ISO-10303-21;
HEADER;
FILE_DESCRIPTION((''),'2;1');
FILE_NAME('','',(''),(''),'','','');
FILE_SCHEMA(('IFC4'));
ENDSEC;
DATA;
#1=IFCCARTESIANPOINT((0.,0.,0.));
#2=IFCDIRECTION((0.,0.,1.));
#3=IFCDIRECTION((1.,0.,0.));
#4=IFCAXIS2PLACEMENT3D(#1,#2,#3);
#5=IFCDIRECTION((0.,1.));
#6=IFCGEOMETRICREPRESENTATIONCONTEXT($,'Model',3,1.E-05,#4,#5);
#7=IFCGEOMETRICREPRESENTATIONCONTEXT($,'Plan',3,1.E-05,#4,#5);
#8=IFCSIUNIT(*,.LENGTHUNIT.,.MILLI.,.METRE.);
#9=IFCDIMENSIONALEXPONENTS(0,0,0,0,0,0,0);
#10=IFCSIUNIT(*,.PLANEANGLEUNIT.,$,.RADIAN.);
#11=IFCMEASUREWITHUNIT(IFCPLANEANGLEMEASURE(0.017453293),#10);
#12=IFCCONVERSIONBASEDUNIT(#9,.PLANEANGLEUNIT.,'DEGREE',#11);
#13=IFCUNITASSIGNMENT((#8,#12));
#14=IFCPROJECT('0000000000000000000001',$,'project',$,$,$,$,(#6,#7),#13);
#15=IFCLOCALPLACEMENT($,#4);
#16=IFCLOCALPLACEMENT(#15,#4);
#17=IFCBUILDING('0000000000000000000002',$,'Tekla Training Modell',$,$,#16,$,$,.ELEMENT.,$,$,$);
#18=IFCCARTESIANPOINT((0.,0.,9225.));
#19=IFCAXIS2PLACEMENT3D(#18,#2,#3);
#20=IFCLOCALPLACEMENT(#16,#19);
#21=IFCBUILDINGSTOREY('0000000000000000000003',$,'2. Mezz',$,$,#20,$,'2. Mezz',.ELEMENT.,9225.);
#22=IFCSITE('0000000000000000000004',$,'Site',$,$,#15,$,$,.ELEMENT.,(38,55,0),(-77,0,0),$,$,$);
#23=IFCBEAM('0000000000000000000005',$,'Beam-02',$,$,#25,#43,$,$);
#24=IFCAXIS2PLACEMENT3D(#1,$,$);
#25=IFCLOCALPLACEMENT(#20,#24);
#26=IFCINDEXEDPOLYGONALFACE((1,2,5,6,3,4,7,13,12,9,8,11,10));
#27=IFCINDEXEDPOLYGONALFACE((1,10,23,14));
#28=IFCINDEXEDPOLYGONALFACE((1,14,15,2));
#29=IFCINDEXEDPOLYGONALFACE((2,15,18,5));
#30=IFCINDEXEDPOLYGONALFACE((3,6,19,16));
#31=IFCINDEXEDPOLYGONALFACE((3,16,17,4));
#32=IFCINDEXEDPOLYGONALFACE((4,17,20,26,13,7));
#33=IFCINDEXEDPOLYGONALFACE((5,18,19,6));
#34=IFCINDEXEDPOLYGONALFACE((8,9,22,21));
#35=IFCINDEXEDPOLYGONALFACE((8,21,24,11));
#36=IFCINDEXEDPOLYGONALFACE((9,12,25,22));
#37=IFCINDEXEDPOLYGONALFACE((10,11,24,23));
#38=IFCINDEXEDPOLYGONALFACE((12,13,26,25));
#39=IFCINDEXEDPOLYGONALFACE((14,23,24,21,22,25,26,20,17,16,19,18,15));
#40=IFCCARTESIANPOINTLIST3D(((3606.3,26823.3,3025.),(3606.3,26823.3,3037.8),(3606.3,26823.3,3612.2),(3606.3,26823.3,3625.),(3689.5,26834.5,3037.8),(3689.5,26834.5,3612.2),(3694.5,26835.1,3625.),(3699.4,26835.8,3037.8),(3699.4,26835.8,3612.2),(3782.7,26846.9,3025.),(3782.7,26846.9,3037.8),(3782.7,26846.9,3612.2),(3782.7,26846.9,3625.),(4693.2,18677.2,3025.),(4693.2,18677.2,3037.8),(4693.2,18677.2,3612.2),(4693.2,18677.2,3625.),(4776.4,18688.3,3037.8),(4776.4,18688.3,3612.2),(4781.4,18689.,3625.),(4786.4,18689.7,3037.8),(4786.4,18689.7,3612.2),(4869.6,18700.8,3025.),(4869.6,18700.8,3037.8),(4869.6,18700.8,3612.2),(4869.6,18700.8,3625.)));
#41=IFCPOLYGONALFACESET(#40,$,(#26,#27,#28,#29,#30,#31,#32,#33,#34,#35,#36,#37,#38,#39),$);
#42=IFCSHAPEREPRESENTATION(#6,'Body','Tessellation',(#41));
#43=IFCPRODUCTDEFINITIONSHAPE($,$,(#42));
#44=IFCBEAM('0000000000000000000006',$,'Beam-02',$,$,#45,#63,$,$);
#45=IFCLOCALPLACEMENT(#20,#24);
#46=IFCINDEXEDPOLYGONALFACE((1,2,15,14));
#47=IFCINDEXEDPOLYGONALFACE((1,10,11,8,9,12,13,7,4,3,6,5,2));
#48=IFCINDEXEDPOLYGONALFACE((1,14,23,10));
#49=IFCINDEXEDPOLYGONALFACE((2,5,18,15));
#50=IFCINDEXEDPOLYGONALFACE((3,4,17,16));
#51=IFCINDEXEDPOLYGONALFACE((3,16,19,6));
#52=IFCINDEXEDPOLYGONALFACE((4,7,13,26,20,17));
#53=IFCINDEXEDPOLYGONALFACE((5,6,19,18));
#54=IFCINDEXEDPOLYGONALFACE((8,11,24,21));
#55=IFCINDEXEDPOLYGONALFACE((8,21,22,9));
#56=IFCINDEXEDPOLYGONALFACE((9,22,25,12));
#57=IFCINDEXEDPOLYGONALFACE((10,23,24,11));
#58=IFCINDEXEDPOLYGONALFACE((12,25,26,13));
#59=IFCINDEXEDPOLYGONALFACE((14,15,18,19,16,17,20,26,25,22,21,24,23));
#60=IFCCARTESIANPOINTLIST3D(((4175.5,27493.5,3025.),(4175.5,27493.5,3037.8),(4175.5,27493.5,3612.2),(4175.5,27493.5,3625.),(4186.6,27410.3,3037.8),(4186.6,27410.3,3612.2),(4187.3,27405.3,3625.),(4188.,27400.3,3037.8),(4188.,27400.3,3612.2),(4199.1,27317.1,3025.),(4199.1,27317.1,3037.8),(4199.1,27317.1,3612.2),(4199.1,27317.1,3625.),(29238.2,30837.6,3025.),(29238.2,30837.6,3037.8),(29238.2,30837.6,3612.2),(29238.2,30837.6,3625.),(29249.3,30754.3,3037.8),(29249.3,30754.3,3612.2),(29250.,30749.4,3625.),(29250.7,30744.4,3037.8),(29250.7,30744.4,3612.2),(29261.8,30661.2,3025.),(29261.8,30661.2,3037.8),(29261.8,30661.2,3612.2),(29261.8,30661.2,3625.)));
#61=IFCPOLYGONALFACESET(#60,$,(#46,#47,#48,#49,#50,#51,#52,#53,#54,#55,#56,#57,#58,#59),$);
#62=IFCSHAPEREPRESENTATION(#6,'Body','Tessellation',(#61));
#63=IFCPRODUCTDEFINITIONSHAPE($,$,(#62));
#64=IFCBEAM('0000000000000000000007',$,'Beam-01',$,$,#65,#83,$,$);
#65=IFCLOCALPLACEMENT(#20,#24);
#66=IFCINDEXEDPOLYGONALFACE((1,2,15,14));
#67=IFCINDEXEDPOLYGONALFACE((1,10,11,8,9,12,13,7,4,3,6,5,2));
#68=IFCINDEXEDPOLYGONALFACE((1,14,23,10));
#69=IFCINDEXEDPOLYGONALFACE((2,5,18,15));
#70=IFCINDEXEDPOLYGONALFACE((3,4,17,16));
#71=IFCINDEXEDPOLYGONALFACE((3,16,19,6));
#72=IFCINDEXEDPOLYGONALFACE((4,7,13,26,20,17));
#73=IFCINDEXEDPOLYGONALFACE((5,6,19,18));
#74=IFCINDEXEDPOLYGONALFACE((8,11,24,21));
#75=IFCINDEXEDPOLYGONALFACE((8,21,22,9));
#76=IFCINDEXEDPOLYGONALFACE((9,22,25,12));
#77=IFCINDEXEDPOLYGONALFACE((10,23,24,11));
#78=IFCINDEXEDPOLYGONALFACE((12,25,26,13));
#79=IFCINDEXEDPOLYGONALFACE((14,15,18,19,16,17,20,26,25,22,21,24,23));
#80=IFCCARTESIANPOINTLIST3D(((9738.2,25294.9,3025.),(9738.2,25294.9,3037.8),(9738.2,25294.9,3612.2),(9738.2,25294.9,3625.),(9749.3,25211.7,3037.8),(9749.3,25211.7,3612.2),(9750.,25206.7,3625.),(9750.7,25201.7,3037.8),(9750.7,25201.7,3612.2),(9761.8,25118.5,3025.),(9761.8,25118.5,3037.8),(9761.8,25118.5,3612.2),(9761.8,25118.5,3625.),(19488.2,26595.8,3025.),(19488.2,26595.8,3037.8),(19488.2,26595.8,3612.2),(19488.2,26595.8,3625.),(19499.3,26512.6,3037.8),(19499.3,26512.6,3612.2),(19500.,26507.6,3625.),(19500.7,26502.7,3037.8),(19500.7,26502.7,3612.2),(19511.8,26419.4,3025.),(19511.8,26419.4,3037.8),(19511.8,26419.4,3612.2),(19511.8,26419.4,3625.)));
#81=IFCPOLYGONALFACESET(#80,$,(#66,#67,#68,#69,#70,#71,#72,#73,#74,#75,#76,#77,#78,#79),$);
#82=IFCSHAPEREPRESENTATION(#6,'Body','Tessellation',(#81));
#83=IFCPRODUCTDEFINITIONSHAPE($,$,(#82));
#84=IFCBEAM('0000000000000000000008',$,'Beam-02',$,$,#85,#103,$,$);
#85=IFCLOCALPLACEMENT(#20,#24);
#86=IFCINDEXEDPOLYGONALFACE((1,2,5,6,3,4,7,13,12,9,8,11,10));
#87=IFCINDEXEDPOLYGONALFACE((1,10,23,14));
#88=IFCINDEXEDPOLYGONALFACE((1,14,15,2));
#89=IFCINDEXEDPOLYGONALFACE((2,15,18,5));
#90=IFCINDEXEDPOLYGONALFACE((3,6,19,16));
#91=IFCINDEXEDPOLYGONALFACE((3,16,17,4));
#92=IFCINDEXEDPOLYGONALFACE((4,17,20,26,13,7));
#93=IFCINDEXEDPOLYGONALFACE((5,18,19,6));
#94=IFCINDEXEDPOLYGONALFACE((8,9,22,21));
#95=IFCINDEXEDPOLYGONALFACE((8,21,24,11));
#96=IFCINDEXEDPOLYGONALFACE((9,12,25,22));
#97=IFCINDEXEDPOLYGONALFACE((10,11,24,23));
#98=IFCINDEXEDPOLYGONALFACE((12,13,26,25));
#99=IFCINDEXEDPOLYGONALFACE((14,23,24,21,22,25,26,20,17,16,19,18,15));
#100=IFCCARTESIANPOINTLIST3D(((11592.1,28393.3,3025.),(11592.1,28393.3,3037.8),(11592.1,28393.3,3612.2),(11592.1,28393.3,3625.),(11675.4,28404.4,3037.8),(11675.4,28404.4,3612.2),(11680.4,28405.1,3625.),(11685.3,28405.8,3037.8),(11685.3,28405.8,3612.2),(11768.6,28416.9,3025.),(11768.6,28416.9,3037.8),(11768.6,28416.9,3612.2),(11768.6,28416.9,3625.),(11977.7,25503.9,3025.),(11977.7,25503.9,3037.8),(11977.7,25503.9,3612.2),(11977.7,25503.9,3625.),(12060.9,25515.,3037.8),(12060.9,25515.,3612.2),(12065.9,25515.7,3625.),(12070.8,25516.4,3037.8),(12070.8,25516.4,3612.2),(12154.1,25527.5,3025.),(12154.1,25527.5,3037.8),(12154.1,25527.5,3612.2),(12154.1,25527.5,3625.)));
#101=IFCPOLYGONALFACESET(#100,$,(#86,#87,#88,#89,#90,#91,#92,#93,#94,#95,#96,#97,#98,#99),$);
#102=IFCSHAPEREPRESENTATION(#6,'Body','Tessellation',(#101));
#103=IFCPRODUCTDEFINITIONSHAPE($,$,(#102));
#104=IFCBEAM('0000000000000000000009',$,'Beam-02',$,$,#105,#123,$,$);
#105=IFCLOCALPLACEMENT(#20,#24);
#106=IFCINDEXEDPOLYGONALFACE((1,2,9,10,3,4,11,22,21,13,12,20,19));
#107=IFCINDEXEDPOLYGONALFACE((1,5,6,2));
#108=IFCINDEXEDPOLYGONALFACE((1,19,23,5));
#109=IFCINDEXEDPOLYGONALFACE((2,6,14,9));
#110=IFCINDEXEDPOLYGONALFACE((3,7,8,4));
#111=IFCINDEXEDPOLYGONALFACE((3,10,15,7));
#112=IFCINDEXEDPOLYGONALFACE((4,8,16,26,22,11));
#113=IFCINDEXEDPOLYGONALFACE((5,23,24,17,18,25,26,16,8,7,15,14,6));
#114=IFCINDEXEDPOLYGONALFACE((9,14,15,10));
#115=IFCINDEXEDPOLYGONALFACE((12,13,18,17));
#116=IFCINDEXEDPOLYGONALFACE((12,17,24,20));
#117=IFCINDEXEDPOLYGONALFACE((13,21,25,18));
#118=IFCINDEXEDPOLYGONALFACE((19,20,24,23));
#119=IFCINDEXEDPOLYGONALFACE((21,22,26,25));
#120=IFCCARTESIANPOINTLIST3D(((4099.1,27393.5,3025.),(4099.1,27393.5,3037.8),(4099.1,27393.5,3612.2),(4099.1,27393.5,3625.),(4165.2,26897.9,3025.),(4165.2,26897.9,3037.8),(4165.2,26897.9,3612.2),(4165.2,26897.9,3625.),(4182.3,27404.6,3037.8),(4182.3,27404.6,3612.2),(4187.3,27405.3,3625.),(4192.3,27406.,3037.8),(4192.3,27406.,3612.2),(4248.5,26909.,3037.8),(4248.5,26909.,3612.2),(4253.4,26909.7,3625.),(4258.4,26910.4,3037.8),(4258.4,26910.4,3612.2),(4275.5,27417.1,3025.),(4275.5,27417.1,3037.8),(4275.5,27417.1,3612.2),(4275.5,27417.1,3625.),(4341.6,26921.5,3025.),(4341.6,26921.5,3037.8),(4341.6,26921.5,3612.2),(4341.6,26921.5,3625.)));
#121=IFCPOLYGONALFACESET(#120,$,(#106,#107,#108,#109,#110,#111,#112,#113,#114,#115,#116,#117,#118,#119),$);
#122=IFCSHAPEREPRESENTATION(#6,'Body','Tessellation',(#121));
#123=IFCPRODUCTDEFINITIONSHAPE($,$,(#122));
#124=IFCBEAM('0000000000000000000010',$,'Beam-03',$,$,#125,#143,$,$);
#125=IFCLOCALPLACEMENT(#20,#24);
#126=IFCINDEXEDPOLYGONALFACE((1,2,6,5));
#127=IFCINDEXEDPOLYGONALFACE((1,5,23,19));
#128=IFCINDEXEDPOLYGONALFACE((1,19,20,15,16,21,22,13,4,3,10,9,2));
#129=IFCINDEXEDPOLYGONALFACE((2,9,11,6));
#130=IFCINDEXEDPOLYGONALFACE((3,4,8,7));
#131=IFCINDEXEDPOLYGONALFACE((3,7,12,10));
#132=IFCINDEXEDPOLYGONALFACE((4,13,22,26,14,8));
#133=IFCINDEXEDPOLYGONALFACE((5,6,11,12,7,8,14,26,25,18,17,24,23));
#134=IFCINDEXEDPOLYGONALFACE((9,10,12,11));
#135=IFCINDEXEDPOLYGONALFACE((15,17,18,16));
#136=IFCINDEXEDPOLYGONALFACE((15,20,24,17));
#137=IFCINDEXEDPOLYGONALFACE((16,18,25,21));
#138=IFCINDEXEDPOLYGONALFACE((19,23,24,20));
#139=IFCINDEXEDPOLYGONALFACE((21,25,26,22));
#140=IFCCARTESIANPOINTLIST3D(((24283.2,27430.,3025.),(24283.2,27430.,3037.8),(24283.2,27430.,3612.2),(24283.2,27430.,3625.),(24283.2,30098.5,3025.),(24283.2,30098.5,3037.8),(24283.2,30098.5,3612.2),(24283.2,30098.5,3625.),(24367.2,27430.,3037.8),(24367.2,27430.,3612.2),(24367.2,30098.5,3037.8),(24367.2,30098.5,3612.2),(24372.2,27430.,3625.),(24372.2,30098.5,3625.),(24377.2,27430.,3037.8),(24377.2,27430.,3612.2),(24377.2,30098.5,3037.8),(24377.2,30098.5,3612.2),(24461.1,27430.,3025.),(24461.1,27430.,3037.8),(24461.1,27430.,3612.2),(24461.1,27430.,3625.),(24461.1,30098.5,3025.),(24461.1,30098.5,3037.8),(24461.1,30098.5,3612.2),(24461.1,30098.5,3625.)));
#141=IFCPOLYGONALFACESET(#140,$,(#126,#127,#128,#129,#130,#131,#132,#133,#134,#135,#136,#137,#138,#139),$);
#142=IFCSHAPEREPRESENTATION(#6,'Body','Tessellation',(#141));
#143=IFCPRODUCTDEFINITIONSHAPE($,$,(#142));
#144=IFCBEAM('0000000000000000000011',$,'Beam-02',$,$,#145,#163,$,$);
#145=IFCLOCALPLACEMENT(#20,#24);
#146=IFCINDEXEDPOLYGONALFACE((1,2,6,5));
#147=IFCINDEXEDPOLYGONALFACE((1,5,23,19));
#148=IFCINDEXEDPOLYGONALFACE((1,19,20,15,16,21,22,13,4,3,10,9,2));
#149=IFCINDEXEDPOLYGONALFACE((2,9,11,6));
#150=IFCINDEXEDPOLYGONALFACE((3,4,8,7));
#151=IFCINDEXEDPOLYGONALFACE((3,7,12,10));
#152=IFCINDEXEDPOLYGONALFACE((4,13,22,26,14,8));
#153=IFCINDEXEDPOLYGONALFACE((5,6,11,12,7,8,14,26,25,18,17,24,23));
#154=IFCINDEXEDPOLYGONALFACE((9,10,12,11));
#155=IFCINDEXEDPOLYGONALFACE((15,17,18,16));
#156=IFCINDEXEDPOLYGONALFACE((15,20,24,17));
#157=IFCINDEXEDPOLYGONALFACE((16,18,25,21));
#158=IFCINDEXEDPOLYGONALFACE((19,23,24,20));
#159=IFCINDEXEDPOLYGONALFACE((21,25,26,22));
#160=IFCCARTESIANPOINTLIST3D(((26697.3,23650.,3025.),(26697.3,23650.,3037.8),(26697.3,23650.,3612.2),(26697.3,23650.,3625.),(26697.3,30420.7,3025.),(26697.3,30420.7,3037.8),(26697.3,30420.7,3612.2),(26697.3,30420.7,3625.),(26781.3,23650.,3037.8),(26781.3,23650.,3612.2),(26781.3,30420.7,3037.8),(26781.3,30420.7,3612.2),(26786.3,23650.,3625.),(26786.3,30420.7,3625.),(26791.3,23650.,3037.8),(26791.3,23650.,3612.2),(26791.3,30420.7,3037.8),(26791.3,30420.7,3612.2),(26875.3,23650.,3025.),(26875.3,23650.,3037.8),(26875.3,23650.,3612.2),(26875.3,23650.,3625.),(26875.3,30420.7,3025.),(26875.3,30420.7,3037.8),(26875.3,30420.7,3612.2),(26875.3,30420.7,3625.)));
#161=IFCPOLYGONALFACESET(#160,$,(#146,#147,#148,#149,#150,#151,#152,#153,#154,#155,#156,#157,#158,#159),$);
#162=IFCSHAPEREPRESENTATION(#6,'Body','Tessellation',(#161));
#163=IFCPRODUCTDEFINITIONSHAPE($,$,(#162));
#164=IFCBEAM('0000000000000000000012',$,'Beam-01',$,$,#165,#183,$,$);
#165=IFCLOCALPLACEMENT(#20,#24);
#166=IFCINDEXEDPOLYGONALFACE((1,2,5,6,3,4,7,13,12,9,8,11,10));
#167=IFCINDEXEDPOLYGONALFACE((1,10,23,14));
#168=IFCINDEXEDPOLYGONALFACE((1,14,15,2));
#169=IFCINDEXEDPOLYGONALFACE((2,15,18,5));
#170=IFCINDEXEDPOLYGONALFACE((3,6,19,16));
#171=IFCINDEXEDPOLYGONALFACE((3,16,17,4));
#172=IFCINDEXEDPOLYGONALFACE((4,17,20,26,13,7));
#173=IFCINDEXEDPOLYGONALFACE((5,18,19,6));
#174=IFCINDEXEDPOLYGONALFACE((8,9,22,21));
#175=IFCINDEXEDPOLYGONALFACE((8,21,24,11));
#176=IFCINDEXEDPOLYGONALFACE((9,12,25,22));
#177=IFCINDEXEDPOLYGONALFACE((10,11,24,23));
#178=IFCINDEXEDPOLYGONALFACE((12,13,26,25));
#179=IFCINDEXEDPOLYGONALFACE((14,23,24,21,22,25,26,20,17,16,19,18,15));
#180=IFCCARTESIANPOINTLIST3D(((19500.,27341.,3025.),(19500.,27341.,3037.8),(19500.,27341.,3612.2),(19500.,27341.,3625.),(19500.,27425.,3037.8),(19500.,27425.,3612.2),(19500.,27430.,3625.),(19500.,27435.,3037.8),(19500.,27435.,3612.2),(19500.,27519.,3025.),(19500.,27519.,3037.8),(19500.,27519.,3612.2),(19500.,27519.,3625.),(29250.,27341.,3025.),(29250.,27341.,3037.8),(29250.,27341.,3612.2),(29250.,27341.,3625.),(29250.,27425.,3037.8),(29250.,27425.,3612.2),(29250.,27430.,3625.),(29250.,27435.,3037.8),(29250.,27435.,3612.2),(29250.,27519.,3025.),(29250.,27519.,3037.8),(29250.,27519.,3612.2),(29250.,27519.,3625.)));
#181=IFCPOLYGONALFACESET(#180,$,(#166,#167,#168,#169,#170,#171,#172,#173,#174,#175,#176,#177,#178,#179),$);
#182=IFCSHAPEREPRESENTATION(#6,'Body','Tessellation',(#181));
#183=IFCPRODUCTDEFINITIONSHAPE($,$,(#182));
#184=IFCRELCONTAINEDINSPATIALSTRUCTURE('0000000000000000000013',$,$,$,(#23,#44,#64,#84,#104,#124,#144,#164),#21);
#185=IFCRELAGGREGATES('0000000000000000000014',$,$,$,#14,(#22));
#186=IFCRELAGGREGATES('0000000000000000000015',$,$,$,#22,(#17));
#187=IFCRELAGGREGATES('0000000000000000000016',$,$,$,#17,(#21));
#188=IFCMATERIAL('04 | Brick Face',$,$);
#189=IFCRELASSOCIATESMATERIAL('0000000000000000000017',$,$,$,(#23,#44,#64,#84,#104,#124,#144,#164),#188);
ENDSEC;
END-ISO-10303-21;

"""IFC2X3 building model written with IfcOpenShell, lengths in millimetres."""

from ifc_helpers import new_model, entity, si_unit, converted_unit, direction, frame, origin_with_axes, place, context, project, spatial, polyline, outline, extrude, material, element, save


model = new_model("IFC2X3")

# Units and contexts
model_context = context("Model", 3, precision=1e-05, world=origin_with_axes(), true_north=direction((0.0, 1.0)))
plan_context = context("Plan", 3, precision=1e-05, world=origin_with_axes(), true_north=direction((0.0, 1.0)))
ifc_project = project(units=[si_unit("LENGTHUNIT", "METRE", prefix="MILLI"), converted_unit("PLANEANGLEUNIT", "DEGREE", entity("IfcPlaneAngleMeasure", 0.017453293), si_unit("PLANEANGLEUNIT", "RADIAN"), dimensions=[0, 0, 0, 0, 0, 0, 0])], contexts=[model_context, plan_context])

# Site, building, storey
site_placement = place(None, origin_with_axes())
site = spatial("IfcSite", under=ifc_project, at=site_placement, Name="Site", CompositionType="ELEMENT", RefLatitude=(38, 55, 0), RefLongitude=(-77, 0, 0))
building_placement = place(site_placement, origin_with_axes())
building = spatial("IfcBuilding", under=site, at=building_placement, Name="Tekla Training Modell", CompositionType="ELEMENT")
storey_placement = place(building_placement, frame((0.0, 0.0, 9225.0), z_axis=(0.0, 0.0, 1.0), x_axis=(1.0, 0.0, 0.0)))
storey = spatial("IfcBuildingStorey", under=building, at=storey_placement, Name="2. Mezz", LongName="2. Mezz", CompositionType="ELEMENT", Elevation=9225.0)

# Shared definitions
ifc_material_1 = material(Name="04 | Brick Face")

# Beams
beam_1_placement = place(storey_placement, frame((3694.5, 26835.1, 3325.0), z_axis=(0.0, 0.0, 1.0), x_axis=(-0.991216, -0.132256, 0.0)))
element("IfcBeam", 1, at=beam_1_placement, inside=storey, material=ifc_material_1, Name="Beam-02", context=model_context, shape_type="SweptSolid", body=[
    extrude(outline(polyline([(0.0, 300.0), (-89.0, 300.0), (-89.0, 287.2), (-5.0, 287.2), (-5.0, -287.2), (-89.0, -287.2), (-89.0, -300.0), (89.0, -300.0), (89.0, -287.2), (5.0, -287.2), (5.0, 287.2), (89.0, 287.2), (89.0, 300.0), (0.0, 300.0)])), frame((0.0, 8218.3, 0.0), z_axis=(0.0, -1.0, 0.0), x_axis=(1.0, 0.0, 0.0)), (0.0, 0.0, 1.0), 8218.3),
])
beam_2_placement = place(storey_placement, frame((4187.3, 27405.3, 3325.0), z_axis=(0.0, 0.0, 1.0), x_axis=(0.132256, -0.991216, 0.0)))
element("IfcBeam", 2, at=beam_2_placement, inside=storey, material=ifc_material_1, Name="Beam-02", context=model_context, shape_type="SweptSolid", body=[
    extrude(outline(polyline([(0.0, 300.0), (-89.0, 300.0), (-89.0, 287.2), (-5.0, 287.2), (-5.0, -287.2), (-89.0, -287.2), (-89.0, -300.0), (89.0, -300.0), (89.0, -287.2), (5.0, -287.2), (5.0, 287.2), (89.0, 287.2), (89.0, 300.0), (0.0, 300.0)])), frame((0.0, 25284.8, 0.0), z_axis=(0.0, -1.0, 0.0), x_axis=(1.0, 0.0, 0.0)), (0.0, 0.0, 1.0), 25284.8),
])
beam_3_placement = place(storey_placement, frame((9750.0, 25206.7, 3325.0), z_axis=(0.0, 0.0, 1.0), x_axis=(0.132256, -0.991216, 0.0)))
element("IfcBeam", 3, at=beam_3_placement, inside=storey, material=ifc_material_1, Name="Beam-01", context=model_context, shape_type="SweptSolid", body=[
    extrude(outline(polyline([(0.0, 300.0), (-89.0, 300.0), (-89.0, 287.2), (-5.0, 287.2), (-5.0, -287.2), (-89.0, -287.2), (-89.0, -300.0), (89.0, -300.0), (89.0, -287.2), (5.0, -287.2), (5.0, 287.2), (89.0, 287.2), (89.0, 300.0), (0.0, 300.0)])), frame((0.0, 9836.4, 0.0), z_axis=(0.0, -1.0, 0.0), x_axis=(1.0, 0.0, 0.0)), (0.0, 0.0, 1.0), 9836.4),
])
beam_4_placement = place(storey_placement, frame((11680.4, 28405.1, 3325.0), z_axis=(0.0, 0.0, 1.0), x_axis=(-0.991216, -0.132256, 0.0)))
element("IfcBeam", 4, at=beam_4_placement, inside=storey, material=ifc_material_1, Name="Beam-02", context=model_context, shape_type="SweptSolid", body=[
    extrude(outline(polyline([(0.0, 300.0), (-89.0, 300.0), (-89.0, 287.2), (-5.0, 287.2), (-5.0, -287.2), (-89.0, -287.2), (-89.0, -300.0), (89.0, -300.0), (89.0, -287.2), (5.0, -287.2), (5.0, 287.2), (89.0, 287.2), (89.0, 300.0), (0.0, 300.0)])), frame((0.0, 2915.0, 0.0), z_axis=(0.0, -1.0, 0.0), x_axis=(1.0, 0.0, 0.0)), (0.0, 0.0, 1.0), 2915.0),
])
beam_5_placement = place(storey_placement, frame((4187.3, 27405.3, 3325.0), z_axis=(0.0, 0.0, 1.0), x_axis=(-0.991216, -0.132256, 0.0)))
element("IfcBeam", 5, at=beam_5_placement, inside=storey, material=ifc_material_1, Name="Beam-02", context=model_context, shape_type="SweptSolid", body=[
    extrude(outline(polyline([(0.0, 300.0), (-89.0, 300.0), (-89.0, 287.2), (-5.0, 287.2), (-5.0, -287.2), (-89.0, -287.2), (-89.0, -300.0), (89.0, -300.0), (89.0, -287.2), (5.0, -287.2), (5.0, 287.2), (89.0, 287.2), (89.0, 300.0), (0.0, 300.0)])), frame((0.0, 500.0, 0.0), z_axis=(0.0, -1.0, 0.0), x_axis=(1.0, 0.0, 0.0)), (0.0, 0.0, 1.0), 500.0),
])
beam_6_placement = place(storey_placement, frame((24372.2, 30098.5, 3325.0), z_axis=(0.0, 0.0, 1.0), x_axis=(-1.0, 0.0, 0.0)))
element("IfcBeam", 6, at=beam_6_placement, inside=storey, material=ifc_material_1, Name="Beam-03", context=model_context, shape_type="SweptSolid", body=[
    extrude(outline(polyline([(0.0, 300.0), (-89.0, 300.0), (-89.0, 287.2), (-5.0, 287.2), (-5.0, -287.2), (-89.0, -287.2), (-89.0, -300.0), (89.0, -300.0), (89.0, -287.2), (5.0, -287.2), (5.0, 287.2), (89.0, 287.2), (89.0, 300.0), (0.0, 300.0)])), frame((0.0, 2668.5, 0.0), z_axis=(0.0, -1.0, 0.0), x_axis=(1.0, 0.0, 0.0)), (0.0, 0.0, 1.0), 2668.5),
])
beam_7_placement = place(storey_placement, frame((26786.3, 23650.0, 3325.0), z_axis=(0.0, 0.0, 1.0), x_axis=(1.0, 0.0, 0.0)))
element("IfcBeam", 7, at=beam_7_placement, inside=storey, material=ifc_material_1, Name="Beam-02", context=model_context, shape_type="SweptSolid", body=[
    extrude(outline(polyline([(0.0, 300.0), (-89.0, 300.0), (-89.0, 287.2), (-5.0, 287.2), (-5.0, -287.2), (-89.0, -287.2), (-89.0, -300.0), (89.0, -300.0), (89.0, -287.2), (5.0, -287.2), (5.0, 287.2), (89.0, 287.2), (89.0, 300.0), (0.0, 300.0)])), frame((0.0, 6770.7, 0.0), z_axis=(0.0, -1.0, 0.0), x_axis=(1.0, 0.0, 0.0)), (0.0, 0.0, 1.0), 6770.7),
])
beam_8_placement = place(storey_placement, frame((19500.0, 27430.0, 3325.0), z_axis=(0.0, 0.0, 1.0), x_axis=(0.0, -1.0, 0.0)))
element("IfcBeam", 8, at=beam_8_placement, inside=storey, material=ifc_material_1, Name="Beam-01", context=model_context, shape_type="SweptSolid", body=[
    extrude(outline(polyline([(0.0, 300.0), (-89.0, 300.0), (-89.0, 287.2), (-5.0, 287.2), (-5.0, -287.2), (-89.0, -287.2), (-89.0, -300.0), (89.0, -300.0), (89.0, -287.2), (5.0, -287.2), (5.0, 287.2), (89.0, 287.2), (89.0, 300.0), (0.0, 300.0)])), frame((0.0, 9750.0, 0.0), z_axis=(0.0, -1.0, 0.0), x_axis=(1.0, 0.0, 0.0)), (0.0, 0.0, 1.0), 9750.0),
])

save(model, "model.ifc")
